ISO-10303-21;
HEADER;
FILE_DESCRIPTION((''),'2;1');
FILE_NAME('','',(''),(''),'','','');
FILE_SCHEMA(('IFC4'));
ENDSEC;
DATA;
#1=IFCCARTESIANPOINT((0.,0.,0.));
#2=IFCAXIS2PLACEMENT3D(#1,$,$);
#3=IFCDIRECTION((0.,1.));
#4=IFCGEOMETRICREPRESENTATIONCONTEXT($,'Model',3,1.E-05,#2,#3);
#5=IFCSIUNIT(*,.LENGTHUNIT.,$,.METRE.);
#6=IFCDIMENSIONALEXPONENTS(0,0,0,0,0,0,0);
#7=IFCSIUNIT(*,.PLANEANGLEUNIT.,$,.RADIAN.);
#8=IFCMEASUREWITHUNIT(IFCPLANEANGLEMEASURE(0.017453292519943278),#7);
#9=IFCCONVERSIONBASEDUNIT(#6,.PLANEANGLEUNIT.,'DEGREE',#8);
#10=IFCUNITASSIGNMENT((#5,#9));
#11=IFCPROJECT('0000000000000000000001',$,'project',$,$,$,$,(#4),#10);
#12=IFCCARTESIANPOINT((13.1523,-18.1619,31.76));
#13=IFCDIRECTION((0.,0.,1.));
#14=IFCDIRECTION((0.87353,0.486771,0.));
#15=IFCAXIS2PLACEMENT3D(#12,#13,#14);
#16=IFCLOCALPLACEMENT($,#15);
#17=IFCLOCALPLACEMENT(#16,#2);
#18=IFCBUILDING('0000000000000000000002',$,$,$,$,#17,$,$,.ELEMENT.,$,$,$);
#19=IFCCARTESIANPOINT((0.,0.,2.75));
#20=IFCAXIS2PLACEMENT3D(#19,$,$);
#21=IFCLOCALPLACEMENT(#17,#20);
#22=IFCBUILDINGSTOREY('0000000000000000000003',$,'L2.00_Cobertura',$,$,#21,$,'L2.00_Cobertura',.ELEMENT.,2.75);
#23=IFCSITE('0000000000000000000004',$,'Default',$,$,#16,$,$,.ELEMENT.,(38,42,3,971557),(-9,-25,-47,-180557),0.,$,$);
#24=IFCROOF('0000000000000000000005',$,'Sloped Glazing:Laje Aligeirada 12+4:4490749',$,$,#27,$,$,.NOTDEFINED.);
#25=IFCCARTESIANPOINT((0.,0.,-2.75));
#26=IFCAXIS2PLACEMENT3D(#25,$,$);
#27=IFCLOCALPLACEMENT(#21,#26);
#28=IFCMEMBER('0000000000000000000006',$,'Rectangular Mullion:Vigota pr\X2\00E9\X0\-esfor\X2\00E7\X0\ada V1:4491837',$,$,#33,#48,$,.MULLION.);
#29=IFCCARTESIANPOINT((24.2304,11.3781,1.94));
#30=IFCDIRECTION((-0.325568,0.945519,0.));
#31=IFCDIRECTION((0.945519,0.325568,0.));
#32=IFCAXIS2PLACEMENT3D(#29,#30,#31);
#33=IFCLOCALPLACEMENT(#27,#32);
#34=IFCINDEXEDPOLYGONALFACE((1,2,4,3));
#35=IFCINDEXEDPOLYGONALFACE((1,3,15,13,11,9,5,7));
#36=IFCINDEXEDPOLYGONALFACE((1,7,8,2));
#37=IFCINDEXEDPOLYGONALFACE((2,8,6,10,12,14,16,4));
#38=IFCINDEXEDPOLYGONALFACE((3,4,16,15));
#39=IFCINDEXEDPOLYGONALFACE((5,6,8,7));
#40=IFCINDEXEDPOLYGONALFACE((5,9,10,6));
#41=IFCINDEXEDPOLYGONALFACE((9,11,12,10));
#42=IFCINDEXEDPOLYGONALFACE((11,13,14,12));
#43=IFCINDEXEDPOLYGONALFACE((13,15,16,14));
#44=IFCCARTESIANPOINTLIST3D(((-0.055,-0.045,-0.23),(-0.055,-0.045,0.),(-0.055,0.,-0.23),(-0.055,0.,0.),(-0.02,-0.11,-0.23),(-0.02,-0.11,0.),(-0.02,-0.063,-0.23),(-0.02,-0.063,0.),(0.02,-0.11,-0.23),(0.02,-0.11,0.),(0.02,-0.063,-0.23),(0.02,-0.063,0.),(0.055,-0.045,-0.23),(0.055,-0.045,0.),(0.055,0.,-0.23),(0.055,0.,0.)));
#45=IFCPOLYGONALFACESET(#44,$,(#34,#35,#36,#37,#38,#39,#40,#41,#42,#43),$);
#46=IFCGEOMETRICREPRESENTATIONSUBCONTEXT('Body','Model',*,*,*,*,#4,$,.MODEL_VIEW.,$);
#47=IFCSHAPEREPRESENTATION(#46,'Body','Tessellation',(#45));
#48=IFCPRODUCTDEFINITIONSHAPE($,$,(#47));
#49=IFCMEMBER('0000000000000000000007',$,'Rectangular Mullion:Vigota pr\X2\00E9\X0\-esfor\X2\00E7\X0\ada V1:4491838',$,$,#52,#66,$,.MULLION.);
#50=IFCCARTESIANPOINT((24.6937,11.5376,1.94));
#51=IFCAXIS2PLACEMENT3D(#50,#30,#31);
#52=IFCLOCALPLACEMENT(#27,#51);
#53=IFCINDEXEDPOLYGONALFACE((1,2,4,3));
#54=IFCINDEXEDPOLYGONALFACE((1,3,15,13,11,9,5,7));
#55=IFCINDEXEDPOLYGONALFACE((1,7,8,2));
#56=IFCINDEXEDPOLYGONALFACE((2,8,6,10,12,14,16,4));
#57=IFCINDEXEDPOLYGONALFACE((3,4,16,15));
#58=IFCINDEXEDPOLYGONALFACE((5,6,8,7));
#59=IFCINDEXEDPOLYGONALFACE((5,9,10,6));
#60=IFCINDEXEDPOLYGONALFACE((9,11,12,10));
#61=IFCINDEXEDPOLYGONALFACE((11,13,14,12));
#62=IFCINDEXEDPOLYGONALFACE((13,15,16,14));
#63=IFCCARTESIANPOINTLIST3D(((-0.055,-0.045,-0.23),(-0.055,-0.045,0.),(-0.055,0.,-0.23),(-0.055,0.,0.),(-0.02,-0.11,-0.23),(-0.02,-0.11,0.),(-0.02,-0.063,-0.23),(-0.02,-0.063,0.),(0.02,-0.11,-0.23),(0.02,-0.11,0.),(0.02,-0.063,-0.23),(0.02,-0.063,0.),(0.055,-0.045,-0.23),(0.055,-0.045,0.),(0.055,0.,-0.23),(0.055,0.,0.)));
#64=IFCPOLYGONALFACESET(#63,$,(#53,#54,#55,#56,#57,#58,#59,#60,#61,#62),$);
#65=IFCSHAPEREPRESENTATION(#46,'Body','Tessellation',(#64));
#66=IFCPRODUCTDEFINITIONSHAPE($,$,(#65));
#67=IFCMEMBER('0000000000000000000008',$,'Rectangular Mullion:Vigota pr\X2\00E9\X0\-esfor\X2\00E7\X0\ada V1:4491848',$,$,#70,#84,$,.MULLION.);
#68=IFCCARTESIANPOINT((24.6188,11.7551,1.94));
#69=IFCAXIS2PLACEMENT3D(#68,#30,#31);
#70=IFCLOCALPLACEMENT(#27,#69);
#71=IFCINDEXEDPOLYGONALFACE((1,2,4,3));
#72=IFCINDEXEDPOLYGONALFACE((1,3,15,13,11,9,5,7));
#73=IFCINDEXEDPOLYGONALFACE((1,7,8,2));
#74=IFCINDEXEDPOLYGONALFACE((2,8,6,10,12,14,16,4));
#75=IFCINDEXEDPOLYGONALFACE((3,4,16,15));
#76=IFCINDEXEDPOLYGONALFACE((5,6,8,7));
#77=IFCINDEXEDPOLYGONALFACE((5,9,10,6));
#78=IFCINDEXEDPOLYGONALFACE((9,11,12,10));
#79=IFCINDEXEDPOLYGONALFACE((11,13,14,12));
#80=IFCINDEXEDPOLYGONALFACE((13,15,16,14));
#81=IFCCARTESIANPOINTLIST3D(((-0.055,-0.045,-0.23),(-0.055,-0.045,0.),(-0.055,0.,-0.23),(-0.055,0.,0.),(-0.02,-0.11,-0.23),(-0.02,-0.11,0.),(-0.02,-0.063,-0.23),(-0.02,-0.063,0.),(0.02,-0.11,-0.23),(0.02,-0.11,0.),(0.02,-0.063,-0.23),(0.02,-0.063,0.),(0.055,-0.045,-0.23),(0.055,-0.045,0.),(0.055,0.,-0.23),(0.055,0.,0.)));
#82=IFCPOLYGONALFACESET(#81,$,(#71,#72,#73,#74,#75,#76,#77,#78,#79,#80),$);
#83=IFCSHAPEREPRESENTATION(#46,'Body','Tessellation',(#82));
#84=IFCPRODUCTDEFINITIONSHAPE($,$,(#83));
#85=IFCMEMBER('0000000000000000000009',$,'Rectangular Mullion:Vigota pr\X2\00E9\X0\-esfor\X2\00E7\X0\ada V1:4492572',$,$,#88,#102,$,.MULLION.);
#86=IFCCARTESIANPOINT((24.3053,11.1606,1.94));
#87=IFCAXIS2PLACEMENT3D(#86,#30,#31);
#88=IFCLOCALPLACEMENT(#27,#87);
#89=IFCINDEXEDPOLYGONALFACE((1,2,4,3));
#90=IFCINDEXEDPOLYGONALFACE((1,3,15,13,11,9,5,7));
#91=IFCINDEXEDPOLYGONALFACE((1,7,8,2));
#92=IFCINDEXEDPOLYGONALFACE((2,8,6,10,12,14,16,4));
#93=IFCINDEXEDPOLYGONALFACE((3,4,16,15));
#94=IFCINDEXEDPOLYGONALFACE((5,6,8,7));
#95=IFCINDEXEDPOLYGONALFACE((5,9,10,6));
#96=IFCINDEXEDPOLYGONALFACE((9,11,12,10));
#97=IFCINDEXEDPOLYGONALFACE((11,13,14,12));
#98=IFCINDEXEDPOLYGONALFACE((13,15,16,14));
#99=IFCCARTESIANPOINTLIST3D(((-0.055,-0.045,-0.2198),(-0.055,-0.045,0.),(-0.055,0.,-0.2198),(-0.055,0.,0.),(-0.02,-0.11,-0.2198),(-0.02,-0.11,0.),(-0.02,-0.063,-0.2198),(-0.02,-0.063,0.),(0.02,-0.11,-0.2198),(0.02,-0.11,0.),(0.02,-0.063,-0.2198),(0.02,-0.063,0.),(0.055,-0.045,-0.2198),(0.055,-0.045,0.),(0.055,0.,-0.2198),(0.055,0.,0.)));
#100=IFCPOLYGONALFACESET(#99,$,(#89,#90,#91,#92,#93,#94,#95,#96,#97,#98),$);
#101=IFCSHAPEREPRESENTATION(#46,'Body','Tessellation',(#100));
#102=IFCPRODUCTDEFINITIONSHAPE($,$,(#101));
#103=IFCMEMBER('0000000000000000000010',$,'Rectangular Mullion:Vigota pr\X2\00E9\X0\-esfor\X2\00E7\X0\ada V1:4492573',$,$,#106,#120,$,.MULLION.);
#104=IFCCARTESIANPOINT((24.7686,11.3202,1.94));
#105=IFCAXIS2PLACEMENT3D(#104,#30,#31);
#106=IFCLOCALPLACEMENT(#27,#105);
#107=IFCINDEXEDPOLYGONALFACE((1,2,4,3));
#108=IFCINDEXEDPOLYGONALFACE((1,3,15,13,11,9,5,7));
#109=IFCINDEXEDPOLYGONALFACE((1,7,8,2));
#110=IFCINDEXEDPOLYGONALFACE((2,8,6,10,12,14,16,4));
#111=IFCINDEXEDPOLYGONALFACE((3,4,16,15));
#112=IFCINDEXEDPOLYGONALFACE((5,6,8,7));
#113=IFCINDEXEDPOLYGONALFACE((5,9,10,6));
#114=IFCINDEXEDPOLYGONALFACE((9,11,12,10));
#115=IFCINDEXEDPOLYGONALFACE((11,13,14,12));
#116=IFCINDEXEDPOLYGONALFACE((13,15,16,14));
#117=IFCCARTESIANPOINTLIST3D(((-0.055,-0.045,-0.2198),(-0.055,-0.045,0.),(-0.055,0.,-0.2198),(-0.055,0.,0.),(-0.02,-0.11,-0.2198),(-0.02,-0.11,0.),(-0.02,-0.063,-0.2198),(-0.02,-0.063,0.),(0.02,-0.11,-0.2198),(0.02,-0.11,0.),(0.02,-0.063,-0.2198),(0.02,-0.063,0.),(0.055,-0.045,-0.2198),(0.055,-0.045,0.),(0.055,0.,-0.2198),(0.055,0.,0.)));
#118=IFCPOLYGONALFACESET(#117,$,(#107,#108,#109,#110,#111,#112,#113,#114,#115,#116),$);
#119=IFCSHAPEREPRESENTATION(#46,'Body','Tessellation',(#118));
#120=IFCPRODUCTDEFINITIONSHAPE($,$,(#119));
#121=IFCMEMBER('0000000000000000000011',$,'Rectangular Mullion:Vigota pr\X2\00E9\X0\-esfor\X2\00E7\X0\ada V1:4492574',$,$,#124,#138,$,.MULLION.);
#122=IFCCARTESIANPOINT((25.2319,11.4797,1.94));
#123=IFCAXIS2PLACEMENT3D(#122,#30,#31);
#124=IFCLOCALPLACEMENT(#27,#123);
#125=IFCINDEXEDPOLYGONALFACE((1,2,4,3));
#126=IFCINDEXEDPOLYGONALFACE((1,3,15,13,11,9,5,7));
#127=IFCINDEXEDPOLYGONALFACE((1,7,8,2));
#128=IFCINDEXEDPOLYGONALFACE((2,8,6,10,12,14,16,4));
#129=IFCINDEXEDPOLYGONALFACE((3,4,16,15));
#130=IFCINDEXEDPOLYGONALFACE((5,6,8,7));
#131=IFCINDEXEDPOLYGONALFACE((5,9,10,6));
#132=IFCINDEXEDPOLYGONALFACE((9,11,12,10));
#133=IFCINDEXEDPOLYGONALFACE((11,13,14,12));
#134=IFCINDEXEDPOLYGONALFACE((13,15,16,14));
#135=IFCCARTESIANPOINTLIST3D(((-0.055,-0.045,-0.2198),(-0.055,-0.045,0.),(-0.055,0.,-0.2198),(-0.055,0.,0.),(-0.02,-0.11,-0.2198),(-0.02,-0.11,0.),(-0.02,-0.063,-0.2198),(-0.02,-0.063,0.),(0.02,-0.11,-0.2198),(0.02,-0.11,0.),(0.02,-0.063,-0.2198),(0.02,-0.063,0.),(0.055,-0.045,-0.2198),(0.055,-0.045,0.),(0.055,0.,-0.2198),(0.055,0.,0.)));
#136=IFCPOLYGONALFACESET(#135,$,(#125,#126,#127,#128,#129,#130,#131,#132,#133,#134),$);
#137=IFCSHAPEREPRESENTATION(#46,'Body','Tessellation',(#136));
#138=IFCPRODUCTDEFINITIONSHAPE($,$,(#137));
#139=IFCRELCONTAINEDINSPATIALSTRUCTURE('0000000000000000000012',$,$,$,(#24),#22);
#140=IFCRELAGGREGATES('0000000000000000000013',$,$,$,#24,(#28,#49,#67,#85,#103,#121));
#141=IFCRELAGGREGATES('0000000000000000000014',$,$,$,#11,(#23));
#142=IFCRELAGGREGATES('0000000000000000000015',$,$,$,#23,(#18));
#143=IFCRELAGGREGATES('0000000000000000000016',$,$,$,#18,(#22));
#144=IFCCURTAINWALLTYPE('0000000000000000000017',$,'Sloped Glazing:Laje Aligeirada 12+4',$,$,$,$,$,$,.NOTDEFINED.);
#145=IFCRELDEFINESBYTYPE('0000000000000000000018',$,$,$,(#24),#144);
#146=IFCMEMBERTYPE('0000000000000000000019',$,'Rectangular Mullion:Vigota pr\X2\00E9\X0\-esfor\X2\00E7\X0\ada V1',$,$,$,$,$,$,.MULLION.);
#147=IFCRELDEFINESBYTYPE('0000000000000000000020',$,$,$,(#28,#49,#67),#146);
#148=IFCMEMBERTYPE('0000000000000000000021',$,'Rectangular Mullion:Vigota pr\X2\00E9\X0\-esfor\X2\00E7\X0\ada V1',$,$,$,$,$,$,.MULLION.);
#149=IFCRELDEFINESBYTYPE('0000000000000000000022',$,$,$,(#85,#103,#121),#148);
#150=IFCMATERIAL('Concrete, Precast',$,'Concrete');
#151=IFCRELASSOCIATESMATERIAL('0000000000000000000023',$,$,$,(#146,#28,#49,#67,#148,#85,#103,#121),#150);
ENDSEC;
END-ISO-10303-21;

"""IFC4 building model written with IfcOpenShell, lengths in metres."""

from ifc_helpers import new_model, entity, si_unit, converted_unit, direction, frame, origin, place, context, subcontext, project, spatial, indexed_curve, outline, extrude, source, transform, mapped, material, type_object, type_shapes, element, aggregate, save


model = new_model("IFC4")

# Units and contexts
model_context = context("Model", 3, precision=1e-05, world=origin(), true_north=direction((0.0, 1.0)))
body_context = subcontext(model_context, "Body", "Model", "MODEL_VIEW")
ifc_project = project(units=[si_unit("LENGTHUNIT", "METRE"), converted_unit("PLANEANGLEUNIT", "DEGREE", entity("IfcPlaneAngleMeasure", 0.017453292519943278), si_unit("PLANEANGLEUNIT", "RADIAN"), dimensions=[0, 0, 0, 0, 0, 0, 0])], contexts=[model_context])

# Site, building, storey
site_placement = place(None, frame((13.1523, -18.1619, 31.76), z_axis=(0.0, 0.0, 1.0), x_axis=(0.87353, 0.486771, 0.0)))
site = spatial("IfcSite", under=ifc_project, at=site_placement, Name="Default", CompositionType="ELEMENT", RefLatitude=(38, 42, 3, 971557), RefLongitude=(-9, -25, -47, -180557), RefElevation=0.0)
building_placement = place(site_placement, origin())
building = spatial("IfcBuilding", under=site, at=building_placement, CompositionType="ELEMENT")
storey_placement = place(building_placement, frame((0.0, 0.0, 2.75)))
storey = spatial("IfcBuildingStorey", under=building, at=storey_placement, Name="L2.00_Cobertura", LongName="L2.00_Cobertura", CompositionType="ELEMENT", Elevation=2.75)

# Roof, members
curtain_wall_type = type_object("IfcCurtainWallType", Name="Sloped Glazing:Laje Aligeirada 12+4", PredefinedType="NOTDEFINED")
roof_placement = place(storey_placement, frame((0.0, 0.0, -2.75)))
roof = element("IfcRoof", 1, at=roof_placement, inside=storey, type_object=curtain_wall_type, Name="Sloped Glazing:Laje Aligeirada 12+4:4490749", PredefinedType="NOTDEFINED")
ifc_material_1 = material(Name="Concrete, Precast", Category="Concrete")
member_type_1 = type_object("IfcMemberType", Name="Rectangular Mullion:Vigota pré-esforçada V1", PredefinedType="MULLION", material=ifc_material_1)
shared_shape_1 = source(origin(), body_context, "Body", "SweptSolid", [
    extrude(outline(indexed_curve([(-0.055, -0.0545), (0.055, -0.0545), (0.055, -0.0095), (0.02, 0.0085), (0.02, 0.0555), (-0.02, 0.0555), (-0.02, 0.0085), (-0.055, -0.0095), (-0.055, -0.0545)], self_intersect=False)), frame((0.0, -0.0545, -0.23), z_axis=(0.0, 0.0, 1.0), x_axis=(-1.0, 0.0, 0.0)), (0.0, 0.0, 1.0), 0.23),
])
type_shapes(member_type_1, [shared_shape_1])
member_1_placement = place(roof_placement, frame((24.2304, 11.3781, 1.94), z_axis=(-0.325568, 0.945519, 0.0), x_axis=(0.945519, 0.325568, 0.0)))
member_1 = element("IfcMember", 2, at=member_1_placement, type_object=member_type_1, material=ifc_material_1, Name="Rectangular Mullion:Vigota pré-esforçada V1:4491837", PredefinedType="MULLION", context=body_context, shape_type="MappedRepresentation", body=[
    mapped(shared_shape_1, transform((0.0, 0.0, 0.0), scale=1.0)),
])
member_2_placement = place(roof_placement, frame((24.6937, 11.5376, 1.94), z_axis=(-0.325568, 0.945519, 0.0), x_axis=(0.945519, 0.325568, 0.0)))
member_2 = element("IfcMember", 3, at=member_2_placement, type_object=member_type_1, material=ifc_material_1, Name="Rectangular Mullion:Vigota pré-esforçada V1:4491838", PredefinedType="MULLION", context=body_context, shape_type="MappedRepresentation", body=[
    mapped(shared_shape_1, transform((0.0, 0.0, 0.0), scale=1.0)),
])
member_3_placement = place(roof_placement, frame((24.6188, 11.7551, 1.94), z_axis=(-0.325568, 0.945519, 0.0), x_axis=(0.945519, 0.325568, 0.0)))
member_3 = element("IfcMember", 4, at=member_3_placement, type_object=member_type_1, material=ifc_material_1, Name="Rectangular Mullion:Vigota pré-esforçada V1:4491848", PredefinedType="MULLION", context=body_context, shape_type="MappedRepresentation", body=[
    mapped(shared_shape_1, transform((0.0, 0.0, 0.0), scale=1.0)),
])
member_type_2 = type_object("IfcMemberType", Name="Rectangular Mullion:Vigota pré-esforçada V1", PredefinedType="MULLION", material=ifc_material_1)
shared_shape_2 = source(origin(), body_context, "Body", "SweptSolid", [
    extrude(outline(indexed_curve([(-0.055, -0.0545), (0.055, -0.0545), (0.055, -0.0095), (0.02, 0.0085), (0.02, 0.0555), (-0.02, 0.0555), (-0.02, 0.0085), (-0.055, -0.0095), (-0.055, -0.0545)], self_intersect=False)), frame((0.0, -0.0545, -0.2198), z_axis=(0.0, 0.0, 1.0), x_axis=(-1.0, 0.0, 0.0)), (0.0, 0.0, 1.0), 0.2198),
])
type_shapes(member_type_2, [shared_shape_2])
member_4_placement = place(roof_placement, frame((24.3053, 11.1606, 1.94), z_axis=(-0.325568, 0.945519, 0.0), x_axis=(0.945519, 0.325568, 0.0)))
member_4 = element("IfcMember", 5, at=member_4_placement, type_object=member_type_2, material=ifc_material_1, Name="Rectangular Mullion:Vigota pré-esforçada V1:4492572", PredefinedType="MULLION", context=body_context, shape_type="MappedRepresentation", body=[
    mapped(shared_shape_2, transform((0.0, 0.0, 0.0), scale=1.0)),
])
member_5_placement = place(roof_placement, frame((24.7686, 11.3202, 1.94), z_axis=(-0.325568, 0.945519, 0.0), x_axis=(0.945519, 0.325568, 0.0)))
member_5 = element("IfcMember", 6, at=member_5_placement, type_object=member_type_2, material=ifc_material_1, Name="Rectangular Mullion:Vigota pré-esforçada V1:4492573", PredefinedType="MULLION", context=body_context, shape_type="MappedRepresentation", body=[
    mapped(shared_shape_2, transform((0.0, 0.0, 0.0), scale=1.0)),
])
member_6_placement = place(roof_placement, frame((25.2319, 11.4797, 1.94), z_axis=(-0.325568, 0.945519, 0.0), x_axis=(0.945519, 0.325568, 0.0)))
member_6 = element("IfcMember", 7, at=member_6_placement, type_object=member_type_2, material=ifc_material_1, Name="Rectangular Mullion:Vigota pré-esforçada V1:4492574", PredefinedType="MULLION", context=body_context, shape_type="MappedRepresentation", body=[
    mapped(shared_shape_2, transform((0.0, 0.0, 0.0), scale=1.0)),
])
aggregate(roof, [member_1, member_2, member_3, member_4, member_5, member_6])

save(model, "model.ifc")
